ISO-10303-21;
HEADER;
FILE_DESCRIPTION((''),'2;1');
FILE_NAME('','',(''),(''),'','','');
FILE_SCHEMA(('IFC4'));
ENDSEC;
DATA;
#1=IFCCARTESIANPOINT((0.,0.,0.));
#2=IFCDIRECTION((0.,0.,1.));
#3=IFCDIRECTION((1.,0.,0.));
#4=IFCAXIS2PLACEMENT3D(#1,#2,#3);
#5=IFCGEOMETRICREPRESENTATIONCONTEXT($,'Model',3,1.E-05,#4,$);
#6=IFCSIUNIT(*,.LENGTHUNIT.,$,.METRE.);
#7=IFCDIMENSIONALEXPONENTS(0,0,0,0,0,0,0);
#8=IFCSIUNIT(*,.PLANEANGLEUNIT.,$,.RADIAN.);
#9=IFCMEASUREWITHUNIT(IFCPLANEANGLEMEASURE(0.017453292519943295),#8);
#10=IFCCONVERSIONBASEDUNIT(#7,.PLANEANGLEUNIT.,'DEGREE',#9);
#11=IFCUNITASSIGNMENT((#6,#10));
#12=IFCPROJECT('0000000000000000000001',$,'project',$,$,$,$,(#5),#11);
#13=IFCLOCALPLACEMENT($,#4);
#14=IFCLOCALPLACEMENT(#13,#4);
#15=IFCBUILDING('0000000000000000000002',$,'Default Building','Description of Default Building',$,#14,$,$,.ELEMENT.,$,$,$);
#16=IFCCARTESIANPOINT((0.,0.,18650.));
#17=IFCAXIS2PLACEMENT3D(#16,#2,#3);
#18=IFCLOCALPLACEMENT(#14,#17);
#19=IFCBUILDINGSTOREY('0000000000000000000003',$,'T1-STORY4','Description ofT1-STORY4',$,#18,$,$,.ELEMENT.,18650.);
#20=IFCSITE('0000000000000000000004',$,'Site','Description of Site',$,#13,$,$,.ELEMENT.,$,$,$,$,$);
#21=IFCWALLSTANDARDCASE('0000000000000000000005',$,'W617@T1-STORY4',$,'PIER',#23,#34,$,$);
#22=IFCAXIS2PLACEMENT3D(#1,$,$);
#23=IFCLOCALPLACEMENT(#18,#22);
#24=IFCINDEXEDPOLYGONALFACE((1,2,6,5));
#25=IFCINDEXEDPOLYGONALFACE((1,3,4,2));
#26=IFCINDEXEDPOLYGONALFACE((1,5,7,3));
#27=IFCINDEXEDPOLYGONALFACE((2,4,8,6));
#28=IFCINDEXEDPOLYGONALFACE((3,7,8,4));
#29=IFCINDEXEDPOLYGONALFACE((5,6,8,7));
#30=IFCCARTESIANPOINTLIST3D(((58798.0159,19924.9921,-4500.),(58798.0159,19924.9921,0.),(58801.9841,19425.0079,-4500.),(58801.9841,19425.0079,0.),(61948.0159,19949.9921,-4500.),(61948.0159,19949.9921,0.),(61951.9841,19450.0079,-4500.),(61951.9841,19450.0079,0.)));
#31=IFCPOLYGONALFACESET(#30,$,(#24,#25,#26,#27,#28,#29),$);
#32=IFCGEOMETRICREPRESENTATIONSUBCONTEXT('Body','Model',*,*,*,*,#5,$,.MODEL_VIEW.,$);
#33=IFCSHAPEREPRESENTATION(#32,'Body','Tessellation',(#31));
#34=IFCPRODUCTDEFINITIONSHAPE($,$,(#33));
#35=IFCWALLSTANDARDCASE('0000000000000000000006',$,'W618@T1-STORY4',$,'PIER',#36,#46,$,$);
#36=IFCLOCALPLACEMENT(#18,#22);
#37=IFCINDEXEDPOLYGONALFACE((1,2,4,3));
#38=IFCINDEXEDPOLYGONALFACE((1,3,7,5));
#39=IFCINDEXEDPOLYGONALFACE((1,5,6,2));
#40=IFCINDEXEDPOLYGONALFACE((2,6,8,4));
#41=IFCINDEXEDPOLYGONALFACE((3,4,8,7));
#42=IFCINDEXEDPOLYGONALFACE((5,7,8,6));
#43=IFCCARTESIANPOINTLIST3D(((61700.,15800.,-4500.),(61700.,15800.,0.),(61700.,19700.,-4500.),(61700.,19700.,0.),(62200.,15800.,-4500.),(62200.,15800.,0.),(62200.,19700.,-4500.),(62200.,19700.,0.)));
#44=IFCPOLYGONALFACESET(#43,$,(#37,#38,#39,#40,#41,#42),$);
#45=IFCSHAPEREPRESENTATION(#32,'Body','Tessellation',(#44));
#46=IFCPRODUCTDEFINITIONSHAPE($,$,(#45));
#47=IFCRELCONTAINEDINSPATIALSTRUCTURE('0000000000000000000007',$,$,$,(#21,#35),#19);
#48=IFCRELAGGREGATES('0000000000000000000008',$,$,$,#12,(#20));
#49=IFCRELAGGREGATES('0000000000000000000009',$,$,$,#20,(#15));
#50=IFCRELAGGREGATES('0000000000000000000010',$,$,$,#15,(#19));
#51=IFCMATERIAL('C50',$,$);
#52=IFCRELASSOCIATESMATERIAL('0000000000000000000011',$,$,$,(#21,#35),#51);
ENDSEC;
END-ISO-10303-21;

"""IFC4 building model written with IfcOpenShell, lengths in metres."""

from ifc_helpers import new_model, entity, si_unit, converted_unit, frame, origin_with_axes, place, context, subcontext, project, spatial, indexed_curve, outline, extrude, material, element, save


model = new_model("IFC4")

# Units and contexts
model_context = context("Model", 3, precision=1e-05, world=origin_with_axes())
body_context = subcontext(model_context, "Body", "Model", "MODEL_VIEW")
ifc_project = project(units=[si_unit("LENGTHUNIT", "METRE"), converted_unit("PLANEANGLEUNIT", "DEGREE", entity("IfcPlaneAngleMeasure", 0.017453292519943295), si_unit("PLANEANGLEUNIT", "RADIAN"), dimensions=[0, 0, 0, 0, 0, 0, 0])], contexts=[model_context])

# Site, building, storey
site_placement = place(None, origin_with_axes())
site = spatial("IfcSite", under=ifc_project, at=site_placement, Name="Site", Description="Description of Site", CompositionType="ELEMENT")
building_placement = place(site_placement, origin_with_axes())
building = spatial("IfcBuilding", under=site, at=building_placement, Name="Default Building", Description="Description of Default Building", CompositionType="ELEMENT")
storey_placement = place(building_placement, frame((0.0, 0.0, 18650.0), z_axis=(0.0, 0.0, 1.0), x_axis=(1.0, 0.0, 0.0)))
storey = spatial("IfcBuildingStorey", under=building, at=storey_placement, Name="T1-STORY4", Description="Description ofT1-STORY4", CompositionType="ELEMENT", Elevation=18650.0)

# Shared definitions
ifc_material_1 = material(Name="C50")

# Walls
wall_1_placement = place(storey_placement, frame((58800.0, 19675.0, -4500.0), z_axis=(0.0, 0.0, 1.0), x_axis=(0.999969, 0.007936, 0.0)))
element("IfcWallStandardCase", 1, at=wall_1_placement, inside=storey, material=ifc_material_1, Name="W617@T1-STORY4", ObjectType="PIER", context=body_context, shape_type="SweptSolid", body=[
    extrude(outline(indexed_curve([(0.0, -250.0), (0.0, 250.0), (3150.0992, 250.0), (3150.0992, -250.0), (0.0, -250.0)], self_intersect=False)), origin_with_axes(), (0.0, 0.0, 1.0), 4500.0),
])
wall_2_placement = place(storey_placement, frame((61950.0, 15800.0, -4500.0), z_axis=(0.0, 0.0, 1.0), x_axis=(0.0, 1.0, 0.0)))
element("IfcWallStandardCase", 2, at=wall_2_placement, inside=storey, material=ifc_material_1, Name="W618@T1-STORY4", ObjectType="PIER", context=body_context, shape_type="SweptSolid", body=[
    extrude(outline(indexed_curve([(0.0, -250.0), (0.0, 250.0), (3900.0, 250.0), (3900.0, -250.0), (0.0, -250.0)], self_intersect=False)), origin_with_axes(), (0.0, 0.0, 1.0), 4500.0),
])

save(model, "model.ifc")
